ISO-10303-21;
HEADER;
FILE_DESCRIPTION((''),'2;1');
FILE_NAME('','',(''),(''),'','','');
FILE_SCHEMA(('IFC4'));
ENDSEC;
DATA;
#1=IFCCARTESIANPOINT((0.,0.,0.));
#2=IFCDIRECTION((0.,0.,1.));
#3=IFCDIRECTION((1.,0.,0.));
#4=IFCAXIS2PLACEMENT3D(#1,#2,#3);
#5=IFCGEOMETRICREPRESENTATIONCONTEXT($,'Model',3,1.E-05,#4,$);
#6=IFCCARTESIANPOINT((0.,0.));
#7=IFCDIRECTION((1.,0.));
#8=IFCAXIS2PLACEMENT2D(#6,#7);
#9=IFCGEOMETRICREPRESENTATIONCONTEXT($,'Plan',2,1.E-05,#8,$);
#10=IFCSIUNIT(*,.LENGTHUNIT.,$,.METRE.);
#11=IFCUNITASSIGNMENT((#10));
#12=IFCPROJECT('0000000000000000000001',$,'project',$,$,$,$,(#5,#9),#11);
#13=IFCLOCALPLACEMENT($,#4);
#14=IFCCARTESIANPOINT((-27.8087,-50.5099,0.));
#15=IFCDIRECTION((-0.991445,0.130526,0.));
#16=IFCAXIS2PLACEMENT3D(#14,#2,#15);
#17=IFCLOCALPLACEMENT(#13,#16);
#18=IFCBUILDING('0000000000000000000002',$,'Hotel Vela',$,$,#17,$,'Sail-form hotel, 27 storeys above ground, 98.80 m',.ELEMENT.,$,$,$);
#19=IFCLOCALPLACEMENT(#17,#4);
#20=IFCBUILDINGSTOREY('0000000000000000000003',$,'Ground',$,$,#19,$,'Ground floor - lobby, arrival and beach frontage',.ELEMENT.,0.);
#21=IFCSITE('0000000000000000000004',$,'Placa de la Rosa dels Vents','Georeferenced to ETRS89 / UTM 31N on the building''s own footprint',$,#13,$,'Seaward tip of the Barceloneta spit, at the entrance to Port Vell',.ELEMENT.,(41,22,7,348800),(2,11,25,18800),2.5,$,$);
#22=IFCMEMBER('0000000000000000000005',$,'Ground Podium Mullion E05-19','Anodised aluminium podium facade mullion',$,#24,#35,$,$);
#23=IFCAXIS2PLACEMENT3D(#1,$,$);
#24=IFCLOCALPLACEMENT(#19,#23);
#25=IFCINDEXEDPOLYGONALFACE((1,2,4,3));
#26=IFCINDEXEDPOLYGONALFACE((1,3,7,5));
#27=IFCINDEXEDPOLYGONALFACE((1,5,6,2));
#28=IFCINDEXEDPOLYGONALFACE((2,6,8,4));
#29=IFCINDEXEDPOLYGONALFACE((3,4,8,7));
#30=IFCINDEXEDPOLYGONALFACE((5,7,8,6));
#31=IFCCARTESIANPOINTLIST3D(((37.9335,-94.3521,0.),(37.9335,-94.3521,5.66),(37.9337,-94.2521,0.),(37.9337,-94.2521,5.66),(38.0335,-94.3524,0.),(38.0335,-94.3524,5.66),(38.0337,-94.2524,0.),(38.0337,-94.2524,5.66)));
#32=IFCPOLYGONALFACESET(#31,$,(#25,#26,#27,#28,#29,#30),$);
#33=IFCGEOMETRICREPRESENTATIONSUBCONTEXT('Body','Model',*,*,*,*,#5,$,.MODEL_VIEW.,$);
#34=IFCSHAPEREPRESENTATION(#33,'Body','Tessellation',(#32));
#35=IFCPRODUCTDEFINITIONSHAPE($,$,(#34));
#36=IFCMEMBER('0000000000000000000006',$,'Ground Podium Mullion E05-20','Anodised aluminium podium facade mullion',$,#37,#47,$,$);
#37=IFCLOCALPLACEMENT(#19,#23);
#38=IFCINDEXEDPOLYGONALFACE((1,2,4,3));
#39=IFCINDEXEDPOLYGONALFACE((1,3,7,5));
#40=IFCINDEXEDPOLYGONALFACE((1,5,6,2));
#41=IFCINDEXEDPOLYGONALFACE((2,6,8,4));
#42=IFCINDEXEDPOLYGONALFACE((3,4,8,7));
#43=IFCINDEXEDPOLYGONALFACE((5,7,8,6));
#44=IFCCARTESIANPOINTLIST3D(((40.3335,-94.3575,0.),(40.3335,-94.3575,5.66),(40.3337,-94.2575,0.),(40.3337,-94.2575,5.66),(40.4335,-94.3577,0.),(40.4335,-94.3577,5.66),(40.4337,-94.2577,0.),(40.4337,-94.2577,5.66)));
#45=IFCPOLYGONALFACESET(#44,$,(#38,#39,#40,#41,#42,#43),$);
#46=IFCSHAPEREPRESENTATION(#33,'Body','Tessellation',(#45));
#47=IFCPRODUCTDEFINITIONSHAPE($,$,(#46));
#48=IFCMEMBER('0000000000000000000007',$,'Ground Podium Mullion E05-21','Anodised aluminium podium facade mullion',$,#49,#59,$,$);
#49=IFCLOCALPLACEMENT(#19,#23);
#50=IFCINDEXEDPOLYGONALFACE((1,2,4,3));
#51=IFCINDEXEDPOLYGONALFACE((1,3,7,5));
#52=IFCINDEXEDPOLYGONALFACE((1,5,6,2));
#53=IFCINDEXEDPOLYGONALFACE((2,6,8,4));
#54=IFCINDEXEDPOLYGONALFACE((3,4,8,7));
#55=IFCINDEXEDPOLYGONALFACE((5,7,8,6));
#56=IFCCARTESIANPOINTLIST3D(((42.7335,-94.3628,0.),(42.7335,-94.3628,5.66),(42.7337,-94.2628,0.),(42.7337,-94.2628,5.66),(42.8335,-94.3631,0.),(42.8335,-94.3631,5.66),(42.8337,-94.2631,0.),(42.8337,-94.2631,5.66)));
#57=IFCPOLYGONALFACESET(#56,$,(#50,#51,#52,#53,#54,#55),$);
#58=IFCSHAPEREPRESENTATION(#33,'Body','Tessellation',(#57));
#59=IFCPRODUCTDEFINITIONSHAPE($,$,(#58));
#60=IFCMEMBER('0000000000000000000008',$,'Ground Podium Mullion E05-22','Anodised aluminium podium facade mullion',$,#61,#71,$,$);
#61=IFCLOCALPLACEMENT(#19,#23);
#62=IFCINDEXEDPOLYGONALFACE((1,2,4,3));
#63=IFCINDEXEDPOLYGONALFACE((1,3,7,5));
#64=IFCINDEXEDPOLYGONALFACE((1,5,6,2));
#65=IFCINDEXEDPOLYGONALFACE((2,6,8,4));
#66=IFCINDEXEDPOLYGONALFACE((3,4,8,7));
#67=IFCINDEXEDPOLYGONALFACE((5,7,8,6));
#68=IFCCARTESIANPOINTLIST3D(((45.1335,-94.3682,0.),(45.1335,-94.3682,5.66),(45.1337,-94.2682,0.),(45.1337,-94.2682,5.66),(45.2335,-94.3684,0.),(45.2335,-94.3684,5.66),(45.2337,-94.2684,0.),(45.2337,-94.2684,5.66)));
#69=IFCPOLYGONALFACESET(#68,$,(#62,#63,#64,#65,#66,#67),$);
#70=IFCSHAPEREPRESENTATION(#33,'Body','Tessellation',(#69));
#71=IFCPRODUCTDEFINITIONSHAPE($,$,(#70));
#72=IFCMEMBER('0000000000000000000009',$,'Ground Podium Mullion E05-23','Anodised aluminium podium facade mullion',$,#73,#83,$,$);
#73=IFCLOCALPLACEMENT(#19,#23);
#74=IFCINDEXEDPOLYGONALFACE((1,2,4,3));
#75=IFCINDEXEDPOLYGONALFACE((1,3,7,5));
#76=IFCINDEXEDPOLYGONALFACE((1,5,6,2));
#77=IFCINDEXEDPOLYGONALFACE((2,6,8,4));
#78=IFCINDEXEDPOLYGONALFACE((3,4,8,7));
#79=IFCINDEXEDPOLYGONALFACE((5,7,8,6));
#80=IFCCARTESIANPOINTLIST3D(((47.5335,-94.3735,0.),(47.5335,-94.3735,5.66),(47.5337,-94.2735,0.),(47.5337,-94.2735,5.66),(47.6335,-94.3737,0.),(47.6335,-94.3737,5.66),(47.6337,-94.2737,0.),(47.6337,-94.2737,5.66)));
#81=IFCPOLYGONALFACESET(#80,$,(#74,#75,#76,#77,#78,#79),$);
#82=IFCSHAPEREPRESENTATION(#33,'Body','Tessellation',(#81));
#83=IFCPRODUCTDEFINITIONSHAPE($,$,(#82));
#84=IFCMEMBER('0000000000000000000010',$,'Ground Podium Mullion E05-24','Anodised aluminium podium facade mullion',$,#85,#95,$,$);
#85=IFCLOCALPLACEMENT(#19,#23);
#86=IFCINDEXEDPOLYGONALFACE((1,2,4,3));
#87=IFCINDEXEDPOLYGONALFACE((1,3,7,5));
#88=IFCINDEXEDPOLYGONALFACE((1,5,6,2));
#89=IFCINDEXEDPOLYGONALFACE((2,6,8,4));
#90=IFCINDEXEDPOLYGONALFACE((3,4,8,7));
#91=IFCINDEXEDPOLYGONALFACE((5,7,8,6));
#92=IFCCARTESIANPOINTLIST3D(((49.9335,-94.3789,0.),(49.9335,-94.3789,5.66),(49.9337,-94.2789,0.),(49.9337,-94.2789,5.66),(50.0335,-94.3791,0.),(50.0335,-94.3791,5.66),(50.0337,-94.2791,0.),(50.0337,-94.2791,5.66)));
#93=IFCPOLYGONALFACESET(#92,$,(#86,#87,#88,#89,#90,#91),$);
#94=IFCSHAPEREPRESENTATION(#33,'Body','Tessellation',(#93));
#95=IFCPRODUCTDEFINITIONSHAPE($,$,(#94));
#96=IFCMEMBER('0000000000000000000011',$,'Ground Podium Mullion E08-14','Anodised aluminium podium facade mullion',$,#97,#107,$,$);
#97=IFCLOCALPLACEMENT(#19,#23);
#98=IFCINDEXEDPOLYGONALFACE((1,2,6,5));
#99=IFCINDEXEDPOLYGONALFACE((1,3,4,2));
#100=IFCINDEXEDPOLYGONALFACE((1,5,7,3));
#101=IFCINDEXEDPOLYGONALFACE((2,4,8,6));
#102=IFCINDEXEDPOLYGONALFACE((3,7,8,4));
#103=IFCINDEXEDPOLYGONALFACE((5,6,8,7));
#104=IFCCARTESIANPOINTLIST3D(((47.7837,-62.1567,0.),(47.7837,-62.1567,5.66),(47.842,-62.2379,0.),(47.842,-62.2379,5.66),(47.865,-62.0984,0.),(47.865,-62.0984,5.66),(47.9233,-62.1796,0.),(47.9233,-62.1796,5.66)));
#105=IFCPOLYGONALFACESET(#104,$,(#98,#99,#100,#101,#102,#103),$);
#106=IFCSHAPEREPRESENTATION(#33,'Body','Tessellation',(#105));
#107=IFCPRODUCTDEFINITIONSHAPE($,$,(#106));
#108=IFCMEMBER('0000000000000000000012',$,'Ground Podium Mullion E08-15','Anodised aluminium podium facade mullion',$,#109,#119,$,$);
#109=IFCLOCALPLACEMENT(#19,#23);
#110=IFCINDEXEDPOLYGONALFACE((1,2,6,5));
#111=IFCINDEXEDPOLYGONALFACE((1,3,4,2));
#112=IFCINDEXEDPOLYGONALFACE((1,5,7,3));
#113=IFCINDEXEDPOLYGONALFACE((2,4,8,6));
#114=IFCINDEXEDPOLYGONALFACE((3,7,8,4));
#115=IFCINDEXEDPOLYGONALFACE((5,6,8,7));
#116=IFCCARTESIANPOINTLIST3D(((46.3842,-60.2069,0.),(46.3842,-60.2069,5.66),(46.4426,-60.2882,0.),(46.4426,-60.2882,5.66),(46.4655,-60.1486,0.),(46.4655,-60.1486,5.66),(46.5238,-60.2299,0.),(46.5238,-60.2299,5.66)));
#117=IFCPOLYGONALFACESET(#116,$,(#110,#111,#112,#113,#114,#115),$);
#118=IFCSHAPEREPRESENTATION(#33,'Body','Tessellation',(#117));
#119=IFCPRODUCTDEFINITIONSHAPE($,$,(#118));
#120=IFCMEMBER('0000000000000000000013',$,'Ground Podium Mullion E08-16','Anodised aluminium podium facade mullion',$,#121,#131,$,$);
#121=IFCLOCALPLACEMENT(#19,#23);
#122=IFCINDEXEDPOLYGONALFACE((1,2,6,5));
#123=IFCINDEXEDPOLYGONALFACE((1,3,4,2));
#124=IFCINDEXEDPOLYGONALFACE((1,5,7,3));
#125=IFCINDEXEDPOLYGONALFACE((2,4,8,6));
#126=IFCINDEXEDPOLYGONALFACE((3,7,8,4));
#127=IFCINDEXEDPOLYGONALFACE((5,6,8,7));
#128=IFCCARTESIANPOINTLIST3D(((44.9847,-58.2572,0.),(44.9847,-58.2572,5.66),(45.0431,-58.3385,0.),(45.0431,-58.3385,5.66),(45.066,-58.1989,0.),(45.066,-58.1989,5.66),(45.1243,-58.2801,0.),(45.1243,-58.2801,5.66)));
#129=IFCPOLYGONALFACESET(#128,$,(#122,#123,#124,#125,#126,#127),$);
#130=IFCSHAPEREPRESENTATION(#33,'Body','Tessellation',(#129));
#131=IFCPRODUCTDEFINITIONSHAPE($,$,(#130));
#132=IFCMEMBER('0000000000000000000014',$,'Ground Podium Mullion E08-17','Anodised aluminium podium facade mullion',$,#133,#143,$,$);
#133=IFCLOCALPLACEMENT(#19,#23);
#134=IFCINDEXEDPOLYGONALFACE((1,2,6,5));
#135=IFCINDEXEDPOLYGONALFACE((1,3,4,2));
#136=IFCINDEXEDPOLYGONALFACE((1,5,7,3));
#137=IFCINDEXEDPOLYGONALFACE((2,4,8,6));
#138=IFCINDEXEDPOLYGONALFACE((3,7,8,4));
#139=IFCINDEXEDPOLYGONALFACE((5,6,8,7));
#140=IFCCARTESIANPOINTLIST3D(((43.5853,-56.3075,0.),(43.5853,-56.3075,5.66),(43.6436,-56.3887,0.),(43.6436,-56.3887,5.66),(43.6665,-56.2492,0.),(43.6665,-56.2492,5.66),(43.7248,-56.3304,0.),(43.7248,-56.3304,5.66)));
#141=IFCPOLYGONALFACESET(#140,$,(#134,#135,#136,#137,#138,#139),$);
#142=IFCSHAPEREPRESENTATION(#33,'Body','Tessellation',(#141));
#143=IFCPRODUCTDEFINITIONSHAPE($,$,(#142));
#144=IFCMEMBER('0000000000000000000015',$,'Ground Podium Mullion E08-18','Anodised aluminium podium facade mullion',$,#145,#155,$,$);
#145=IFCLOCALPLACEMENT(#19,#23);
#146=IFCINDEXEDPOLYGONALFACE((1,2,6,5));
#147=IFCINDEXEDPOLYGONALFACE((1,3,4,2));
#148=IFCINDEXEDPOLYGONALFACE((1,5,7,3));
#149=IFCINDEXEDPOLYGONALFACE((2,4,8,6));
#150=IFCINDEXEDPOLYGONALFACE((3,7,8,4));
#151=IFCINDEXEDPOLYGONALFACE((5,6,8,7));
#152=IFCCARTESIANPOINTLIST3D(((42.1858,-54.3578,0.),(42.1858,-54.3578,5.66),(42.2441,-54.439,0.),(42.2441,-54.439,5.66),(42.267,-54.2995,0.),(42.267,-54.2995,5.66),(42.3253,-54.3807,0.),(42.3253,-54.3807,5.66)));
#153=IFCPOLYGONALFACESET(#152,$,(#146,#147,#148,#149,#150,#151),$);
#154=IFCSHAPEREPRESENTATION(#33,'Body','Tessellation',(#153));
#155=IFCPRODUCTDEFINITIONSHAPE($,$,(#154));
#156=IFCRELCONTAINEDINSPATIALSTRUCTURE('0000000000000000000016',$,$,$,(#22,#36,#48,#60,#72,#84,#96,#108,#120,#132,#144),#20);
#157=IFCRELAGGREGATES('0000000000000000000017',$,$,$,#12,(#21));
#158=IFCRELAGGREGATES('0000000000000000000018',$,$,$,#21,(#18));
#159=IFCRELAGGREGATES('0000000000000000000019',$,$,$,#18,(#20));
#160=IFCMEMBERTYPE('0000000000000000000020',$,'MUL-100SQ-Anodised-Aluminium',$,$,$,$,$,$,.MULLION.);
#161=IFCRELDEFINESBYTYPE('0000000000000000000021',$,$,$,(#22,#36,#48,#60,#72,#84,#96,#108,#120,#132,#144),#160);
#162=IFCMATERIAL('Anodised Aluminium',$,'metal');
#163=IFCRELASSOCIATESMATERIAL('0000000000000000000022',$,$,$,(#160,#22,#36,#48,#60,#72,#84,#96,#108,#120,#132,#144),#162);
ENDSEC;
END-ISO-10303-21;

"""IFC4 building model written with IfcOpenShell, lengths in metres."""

from ifc_helpers import new_model, si_unit, frame, origin_with_axes, origin_2d_with_axis, place, context, subcontext, project, spatial, line, indexed_curve, rectangle, outline, extrude, material, material_profile, profile_set, profile_usage, type_object, element, save


model = new_model("IFC4")

# Units and contexts
model_context = context("Model", 3, precision=1e-05, world=origin_with_axes())
plan_context = context("Plan", 2, precision=1e-05, world=origin_2d_with_axis())
body_context = subcontext(model_context, "Body", "Model", "MODEL_VIEW")
ifc_project = project(units=[si_unit("LENGTHUNIT", "METRE")], contexts=[model_context, plan_context])

# Site, building, storey
site_placement = place(None, origin_with_axes())
site = spatial("IfcSite", under=ifc_project, at=site_placement, Name="Placa de la Rosa dels Vents", Description="Georeferenced to ETRS89 / UTM 31N on the building's own footprint", LongName="Seaward tip of the Barceloneta spit, at the entrance to Port Vell", CompositionType="ELEMENT", RefLatitude=(41, 22, 7, 348800), RefLongitude=(2, 11, 25, 18800), RefElevation=2.5)
building_placement = place(site_placement, frame((-27.8087, -50.5099, 0.0), z_axis=(0.0, 0.0, 1.0), x_axis=(-0.991445, 0.130526, 0.0)))
building = spatial("IfcBuilding", under=site, at=building_placement, Name="Hotel Vela", LongName="Sail-form hotel, 27 storeys above ground, 98.80 m", CompositionType="ELEMENT")
storey_placement = place(building_placement, origin_with_axes())
storey = spatial("IfcBuildingStorey", under=building, at=storey_placement, Name="Ground", LongName="Ground floor - lobby, arrival and beach frontage", CompositionType="ELEMENT", Elevation=0.0)

# Members
ifc_material = material(Name="Anodised Aluminium", Category="metal")
ifc_material_profile = material_profile(ifc_material, rectangle(XDim=0.1, YDim=0.1))
ifc_profile_set = profile_set([ifc_material_profile], Name="MUL-100SQ-Anodised-Aluminium")
member_type = type_object("IfcMemberType", Name="MUL-100SQ-Anodised-Aluminium", PredefinedType="MULLION", material=ifc_profile_set)
ifc_profile_usage_1 = profile_usage(ifc_profile_set)
member_1_placement = place(storey_placement, frame((37.9335, -94.3521, 0.0), z_axis=(0.0, 0.0, 1.0), x_axis=(0.999998, -0.002226, 0.0)))
element("IfcMember", 1, at=member_1_placement, inside=storey, type_object=member_type, material=ifc_profile_usage_1, Name="Ground Podium Mullion E05-19", Description="Anodised aluminium podium facade mullion", context=body_context, shape_type="SweptSolid", body=[
    extrude(outline(indexed_curve([(0.0, 0.0), (0.1, 0.0), (0.1, 0.1), (0.0, 0.1)], segments=[line(1, 2, 3, 4, 1)])), origin_with_axes(), (0.0, 0.0, 1.0), 5.66),
])
ifc_profile_usage_2 = profile_usage(ifc_profile_set)
member_2_placement = place(storey_placement, frame((40.3335, -94.3575, 0.0), z_axis=(0.0, 0.0, 1.0), x_axis=(0.999998, -0.002226, 0.0)))
element("IfcMember", 2, at=member_2_placement, inside=storey, type_object=member_type, material=ifc_profile_usage_2, Name="Ground Podium Mullion E05-20", Description="Anodised aluminium podium facade mullion", context=body_context, shape_type="SweptSolid", body=[
    extrude(outline(indexed_curve([(0.0, 0.0), (0.1, 0.0), (0.1, 0.1), (0.0, 0.1)], segments=[line(1, 2, 3, 4, 1)])), origin_with_axes(), (0.0, 0.0, 1.0), 5.66),
])
ifc_profile_usage_3 = profile_usage(ifc_profile_set)
member_3_placement = place(storey_placement, frame((42.7335, -94.3628, 0.0), z_axis=(0.0, 0.0, 1.0), x_axis=(0.999998, -0.002226, 0.0)))
element("IfcMember", 3, at=member_3_placement, inside=storey, type_object=member_type, material=ifc_profile_usage_3, Name="Ground Podium Mullion E05-21", Description="Anodised aluminium podium facade mullion", context=body_context, shape_type="SweptSolid", body=[
    extrude(outline(indexed_curve([(0.0, 0.0), (0.1, 0.0), (0.1, 0.1), (0.0, 0.1)], segments=[line(1, 2, 3, 4, 1)])), origin_with_axes(), (0.0, 0.0, 1.0), 5.66),
])
ifc_profile_usage_4 = profile_usage(ifc_profile_set)
member_4_placement = place(storey_placement, frame((45.1335, -94.3682, 0.0), z_axis=(0.0, 0.0, 1.0), x_axis=(0.999998, -0.002226, 0.0)))
element("IfcMember", 4, at=member_4_placement, inside=storey, type_object=member_type, material=ifc_profile_usage_4, Name="Ground Podium Mullion E05-22", Description="Anodised aluminium podium facade mullion", context=body_context, shape_type="SweptSolid", body=[
    extrude(outline(indexed_curve([(0.0, 0.0), (0.1, 0.0), (0.1, 0.1), (0.0, 0.1)], segments=[line(1, 2, 3, 4, 1)])), origin_with_axes(), (0.0, 0.0, 1.0), 5.66),
])
ifc_profile_usage_5 = profile_usage(ifc_profile_set)
member_5_placement = place(storey_placement, frame((47.5335, -94.3735, 0.0), z_axis=(0.0, 0.0, 1.0), x_axis=(0.999998, -0.002226, 0.0)))
element("IfcMember", 5, at=member_5_placement, inside=storey, type_object=member_type, material=ifc_profile_usage_5, Name="Ground Podium Mullion E05-23", Description="Anodised aluminium podium facade mullion", context=body_context, shape_type="SweptSolid", body=[
    extrude(outline(indexed_curve([(0.0, 0.0), (0.1, 0.0), (0.1, 0.1), (0.0, 0.1)], segments=[line(1, 2, 3, 4, 1)])), origin_with_axes(), (0.0, 0.0, 1.0), 5.66),
])
ifc_profile_usage_6 = profile_usage(ifc_profile_set)
member_6_placement = place(storey_placement, frame((49.9335, -94.3789, 0.0), z_axis=(0.0, 0.0, 1.0), x_axis=(0.999998, -0.002226, 0.0)))
element("IfcMember", 6, at=member_6_placement, inside=storey, type_object=member_type, material=ifc_profile_usage_6, Name="Ground Podium Mullion E05-24", Description="Anodised aluminium podium facade mullion", context=body_context, shape_type="SweptSolid", body=[
    extrude(outline(indexed_curve([(0.0, 0.0), (0.1, 0.0), (0.1, 0.1), (0.0, 0.1)], segments=[line(1, 2, 3, 4, 1)])), origin_with_axes(), (0.0, 0.0, 1.0), 5.66),
])
ifc_profile_usage_7 = profile_usage(ifc_profile_set)
member_7_placement = place(storey_placement, frame((47.9233, -62.1796, 0.0), z_axis=(0.0, 0.0, 1.0), x_axis=(-0.583121, 0.812385, 0.0)))
element("IfcMember", 7, at=member_7_placement, inside=storey, type_object=member_type, material=ifc_profile_usage_7, Name="Ground Podium Mullion E08-14", Description="Anodised aluminium podium facade mullion", context=body_context, shape_type="SweptSolid", body=[
    extrude(outline(indexed_curve([(0.0, 0.0), (0.1, 0.0), (0.1, 0.1), (0.0, 0.1)], segments=[line(1, 2, 3, 4, 1)])), origin_with_axes(), (0.0, 0.0, 1.0), 5.66),
])
ifc_profile_usage_8 = profile_usage(ifc_profile_set)
member_8_placement = place(storey_placement, frame((46.5238, -60.2299, 0.0), z_axis=(0.0, 0.0, 1.0), x_axis=(-0.583121, 0.812385, 0.0)))
element("IfcMember", 8, at=member_8_placement, inside=storey, type_object=member_type, material=ifc_profile_usage_8, Name="Ground Podium Mullion E08-15", Description="Anodised aluminium podium facade mullion", context=body_context, shape_type="SweptSolid", body=[
    extrude(outline(indexed_curve([(0.0, 0.0), (0.1, 0.0), (0.1, 0.1), (0.0, 0.1)], segments=[line(1, 2, 3, 4, 1)])), origin_with_axes(), (0.0, 0.0, 1.0), 5.66),
])
ifc_profile_usage_9 = profile_usage(ifc_profile_set)
member_9_placement = place(storey_placement, frame((45.1243, -58.2801, 0.0), z_axis=(0.0, 0.0, 1.0), x_axis=(-0.583121, 0.812385, 0.0)))
element("IfcMember", 9, at=member_9_placement, inside=storey, type_object=member_type, material=ifc_profile_usage_9, Name="Ground Podium Mullion E08-16", Description="Anodised aluminium podium facade mullion", context=body_context, shape_type="SweptSolid", body=[
    extrude(outline(indexed_curve([(0.0, 0.0), (0.1, 0.0), (0.1, 0.1), (0.0, 0.1)], segments=[line(1, 2, 3, 4, 1)])), origin_with_axes(), (0.0, 0.0, 1.0), 5.66),
])
ifc_profile_usage_10 = profile_usage(ifc_profile_set)
member_10_placement = place(storey_placement, frame((43.7248, -56.3304, 0.0), z_axis=(0.0, 0.0, 1.0), x_axis=(-0.583121, 0.812385, 0.0)))
element("IfcMember", 10, at=member_10_placement, inside=storey, type_object=member_type, material=ifc_profile_usage_10, Name="Ground Podium Mullion E08-17", Description="Anodised aluminium podium facade mullion", context=body_context, shape_type="SweptSolid", body=[
    extrude(outline(indexed_curve([(0.0, 0.0), (0.1, 0.0), (0.1, 0.1), (0.0, 0.1)], segments=[line(1, 2, 3, 4, 1)])), origin_with_axes(), (0.0, 0.0, 1.0), 5.66),
])
ifc_profile_usage_11 = profile_usage(ifc_profile_set)
member_11_placement = place(storey_placement, frame((42.3253, -54.3807, 0.0), z_axis=(0.0, 0.0, 1.0), x_axis=(-0.583121, 0.812385, 0.0)))
element("IfcMember", 11, at=member_11_placement, inside=storey, type_object=member_type, material=ifc_profile_usage_11, Name="Ground Podium Mullion E08-18", Description="Anodised aluminium podium facade mullion", context=body_context, shape_type="SweptSolid", body=[
    extrude(outline(indexed_curve([(0.0, 0.0), (0.1, 0.0), (0.1, 0.1), (0.0, 0.1)], segments=[line(1, 2, 3, 4, 1)])), origin_with_axes(), (0.0, 0.0, 1.0), 5.66),
])

save(model, "model.ifc")
